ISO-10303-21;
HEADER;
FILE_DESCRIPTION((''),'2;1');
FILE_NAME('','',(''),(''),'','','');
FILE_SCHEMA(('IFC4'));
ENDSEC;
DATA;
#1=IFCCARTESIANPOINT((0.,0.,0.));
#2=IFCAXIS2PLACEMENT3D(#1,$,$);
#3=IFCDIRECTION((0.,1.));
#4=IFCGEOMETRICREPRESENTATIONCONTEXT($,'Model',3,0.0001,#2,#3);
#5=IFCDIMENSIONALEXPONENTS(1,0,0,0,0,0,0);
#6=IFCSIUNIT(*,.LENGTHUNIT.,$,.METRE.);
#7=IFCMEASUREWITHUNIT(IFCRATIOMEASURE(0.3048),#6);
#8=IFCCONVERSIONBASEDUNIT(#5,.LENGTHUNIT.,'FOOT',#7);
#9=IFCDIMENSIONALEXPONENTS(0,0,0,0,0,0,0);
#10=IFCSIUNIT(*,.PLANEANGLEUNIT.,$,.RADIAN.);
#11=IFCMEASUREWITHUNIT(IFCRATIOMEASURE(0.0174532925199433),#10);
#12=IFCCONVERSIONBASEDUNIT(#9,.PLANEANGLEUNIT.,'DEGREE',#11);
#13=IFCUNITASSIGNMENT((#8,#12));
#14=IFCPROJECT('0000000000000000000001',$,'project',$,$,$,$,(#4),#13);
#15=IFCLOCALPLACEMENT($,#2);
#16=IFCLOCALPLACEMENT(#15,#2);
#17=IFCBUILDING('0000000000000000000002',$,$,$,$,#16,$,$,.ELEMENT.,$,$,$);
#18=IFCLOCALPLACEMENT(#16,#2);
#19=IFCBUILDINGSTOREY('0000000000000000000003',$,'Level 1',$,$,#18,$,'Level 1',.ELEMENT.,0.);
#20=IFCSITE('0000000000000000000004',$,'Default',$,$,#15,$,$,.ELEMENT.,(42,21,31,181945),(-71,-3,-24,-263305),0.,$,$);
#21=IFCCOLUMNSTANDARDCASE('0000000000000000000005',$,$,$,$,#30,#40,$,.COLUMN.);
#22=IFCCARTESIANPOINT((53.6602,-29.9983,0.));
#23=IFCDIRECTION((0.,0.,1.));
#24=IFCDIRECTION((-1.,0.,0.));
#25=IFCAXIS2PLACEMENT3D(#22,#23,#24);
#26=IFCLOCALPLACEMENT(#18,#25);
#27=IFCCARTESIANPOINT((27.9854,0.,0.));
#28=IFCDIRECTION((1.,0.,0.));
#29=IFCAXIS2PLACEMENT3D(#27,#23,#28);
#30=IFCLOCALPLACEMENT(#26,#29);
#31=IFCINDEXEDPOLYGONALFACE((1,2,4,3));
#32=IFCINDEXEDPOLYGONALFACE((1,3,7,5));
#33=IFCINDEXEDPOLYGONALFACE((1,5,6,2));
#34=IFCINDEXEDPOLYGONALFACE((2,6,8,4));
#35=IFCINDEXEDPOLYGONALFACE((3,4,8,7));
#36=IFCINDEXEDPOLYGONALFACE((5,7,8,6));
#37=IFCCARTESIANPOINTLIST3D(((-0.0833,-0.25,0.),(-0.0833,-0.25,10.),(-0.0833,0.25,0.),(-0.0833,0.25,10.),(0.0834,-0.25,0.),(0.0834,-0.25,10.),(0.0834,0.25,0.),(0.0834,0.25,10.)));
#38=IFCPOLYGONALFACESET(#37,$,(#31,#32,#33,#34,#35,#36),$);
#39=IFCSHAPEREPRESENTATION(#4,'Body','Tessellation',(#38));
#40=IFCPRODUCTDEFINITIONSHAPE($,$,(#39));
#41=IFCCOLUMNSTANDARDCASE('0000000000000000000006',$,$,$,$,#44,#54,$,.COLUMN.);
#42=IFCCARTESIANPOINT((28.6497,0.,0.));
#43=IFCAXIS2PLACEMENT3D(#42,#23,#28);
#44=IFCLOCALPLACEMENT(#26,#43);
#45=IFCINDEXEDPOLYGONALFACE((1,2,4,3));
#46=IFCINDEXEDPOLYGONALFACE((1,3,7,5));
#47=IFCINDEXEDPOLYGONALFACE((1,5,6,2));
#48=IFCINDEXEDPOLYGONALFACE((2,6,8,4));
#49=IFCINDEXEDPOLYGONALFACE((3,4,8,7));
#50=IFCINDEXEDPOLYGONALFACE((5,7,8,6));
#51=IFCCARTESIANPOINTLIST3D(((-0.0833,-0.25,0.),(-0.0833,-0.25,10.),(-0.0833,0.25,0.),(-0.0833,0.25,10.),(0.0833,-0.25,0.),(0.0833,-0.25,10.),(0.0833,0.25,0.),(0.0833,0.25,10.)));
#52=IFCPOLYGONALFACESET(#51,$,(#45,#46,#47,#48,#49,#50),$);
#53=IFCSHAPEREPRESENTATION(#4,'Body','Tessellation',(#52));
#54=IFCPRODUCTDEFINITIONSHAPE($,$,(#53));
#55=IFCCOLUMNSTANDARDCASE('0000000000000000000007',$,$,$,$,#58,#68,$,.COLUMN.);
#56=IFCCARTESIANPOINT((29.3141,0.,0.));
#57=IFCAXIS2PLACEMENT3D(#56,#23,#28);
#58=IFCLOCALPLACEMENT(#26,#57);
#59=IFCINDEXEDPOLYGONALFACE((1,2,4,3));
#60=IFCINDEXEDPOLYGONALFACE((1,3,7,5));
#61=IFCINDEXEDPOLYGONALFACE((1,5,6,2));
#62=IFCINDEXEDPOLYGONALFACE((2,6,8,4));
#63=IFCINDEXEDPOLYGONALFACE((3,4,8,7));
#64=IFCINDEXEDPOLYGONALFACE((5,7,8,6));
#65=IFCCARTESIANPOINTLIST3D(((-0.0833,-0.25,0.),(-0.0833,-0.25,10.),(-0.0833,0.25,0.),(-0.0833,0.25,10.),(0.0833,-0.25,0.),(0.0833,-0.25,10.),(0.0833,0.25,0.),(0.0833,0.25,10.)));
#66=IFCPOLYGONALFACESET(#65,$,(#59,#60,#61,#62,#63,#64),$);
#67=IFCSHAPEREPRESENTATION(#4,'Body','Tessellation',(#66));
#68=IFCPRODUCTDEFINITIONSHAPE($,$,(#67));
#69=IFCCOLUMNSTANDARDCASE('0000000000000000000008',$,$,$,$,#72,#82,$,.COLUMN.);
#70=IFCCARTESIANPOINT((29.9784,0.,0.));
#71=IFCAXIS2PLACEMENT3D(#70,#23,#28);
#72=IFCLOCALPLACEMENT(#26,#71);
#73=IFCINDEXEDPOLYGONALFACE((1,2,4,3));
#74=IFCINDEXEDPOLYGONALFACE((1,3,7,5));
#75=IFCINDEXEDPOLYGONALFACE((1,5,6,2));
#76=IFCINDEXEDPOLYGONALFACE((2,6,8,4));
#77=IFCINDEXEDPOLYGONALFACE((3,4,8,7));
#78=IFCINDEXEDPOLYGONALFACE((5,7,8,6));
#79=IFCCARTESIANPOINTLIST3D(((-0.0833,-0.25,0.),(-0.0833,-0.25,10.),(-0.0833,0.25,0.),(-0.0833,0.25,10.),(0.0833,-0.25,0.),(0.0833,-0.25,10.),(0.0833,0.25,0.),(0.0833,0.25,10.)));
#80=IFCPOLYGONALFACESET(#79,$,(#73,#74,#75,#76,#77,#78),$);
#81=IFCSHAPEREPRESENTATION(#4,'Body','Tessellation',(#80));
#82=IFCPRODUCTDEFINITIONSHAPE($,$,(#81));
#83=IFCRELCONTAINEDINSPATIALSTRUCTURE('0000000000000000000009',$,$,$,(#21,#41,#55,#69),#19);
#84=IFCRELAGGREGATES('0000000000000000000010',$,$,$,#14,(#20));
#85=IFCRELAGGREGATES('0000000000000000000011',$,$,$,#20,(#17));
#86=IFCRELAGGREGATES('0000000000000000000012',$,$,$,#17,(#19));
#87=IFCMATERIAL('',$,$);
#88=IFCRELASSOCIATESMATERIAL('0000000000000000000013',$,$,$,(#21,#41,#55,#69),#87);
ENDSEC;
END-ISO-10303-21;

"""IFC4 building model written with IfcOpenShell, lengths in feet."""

from ifc_helpers import new_model, entity, si_unit, converted_unit, direction, frame, origin, place, context, project, spatial, rectangle, extrude, material, element, save


model = new_model("IFC4")

# Units and contexts
model_context = context("Model", 3, precision=0.0001, world=origin(), true_north=direction((0.0, 1.0)))
ifc_project = project(units=[converted_unit("LENGTHUNIT", "FOOT", entity("IfcRatioMeasure", 0.3048), si_unit("LENGTHUNIT", "METRE"), dimensions=[1, 0, 0, 0, 0, 0, 0]), converted_unit("PLANEANGLEUNIT", "DEGREE", entity("IfcRatioMeasure", 0.0174532925199433), si_unit("PLANEANGLEUNIT", "RADIAN"), dimensions=[0, 0, 0, 0, 0, 0, 0])], contexts=[model_context])

# Site, building, storey
site_placement = place(None, origin())
site = spatial("IfcSite", under=ifc_project, at=site_placement, Name="Default", CompositionType="ELEMENT", RefLatitude=(42, 21, 31, 181945), RefLongitude=(-71, -3, -24, -263305), RefElevation=0.0)
building_placement = place(site_placement, origin())
building = spatial("IfcBuilding", under=site, at=building_placement, CompositionType="ELEMENT")
storey_placement = place(building_placement, origin())
storey = spatial("IfcBuildingStorey", under=building, at=storey_placement, Name="Level 1", LongName="Level 1", CompositionType="ELEMENT", Elevation=0.0)

# Columns
ifc_material_1 = material(Name="")
placement = place(storey_placement, frame((53.6602, -29.9983, 0.0), z_axis=(0.0, 0.0, 1.0), x_axis=(-1.0, 0.0, 0.0)))
for number, where, z_axis, x_axis in (
    (1, (27.9854, 0.0, 0.0), (0.0, 0.0, 1.0), (1.0, 0.0, 0.0)),
    (2, (28.6497, 0.0, 0.0), (0.0, 0.0, 1.0), (1.0, 0.0, 0.0)),
    (3, (29.3141, 0.0, 0.0), (0.0, 0.0, 1.0), (1.0, 0.0, 0.0)),
    (4, (29.9784, 0.0, 0.0), (0.0, 0.0, 1.0), (1.0, 0.0, 0.0)),
):
    element("IfcColumnStandardCase", number, at=place(placement, frame(where, z_axis=z_axis, x_axis=x_axis)), inside=storey, material=ifc_material_1, PredefinedType="COLUMN", context=model_context, shape_type="SweptSolid", body=[
        extrude(rectangle(XDim=0.1667, YDim=0.5), origin(), (0.0, 0.0, 1.0), 10.0),
    ])

save(model, "model.ifc")
